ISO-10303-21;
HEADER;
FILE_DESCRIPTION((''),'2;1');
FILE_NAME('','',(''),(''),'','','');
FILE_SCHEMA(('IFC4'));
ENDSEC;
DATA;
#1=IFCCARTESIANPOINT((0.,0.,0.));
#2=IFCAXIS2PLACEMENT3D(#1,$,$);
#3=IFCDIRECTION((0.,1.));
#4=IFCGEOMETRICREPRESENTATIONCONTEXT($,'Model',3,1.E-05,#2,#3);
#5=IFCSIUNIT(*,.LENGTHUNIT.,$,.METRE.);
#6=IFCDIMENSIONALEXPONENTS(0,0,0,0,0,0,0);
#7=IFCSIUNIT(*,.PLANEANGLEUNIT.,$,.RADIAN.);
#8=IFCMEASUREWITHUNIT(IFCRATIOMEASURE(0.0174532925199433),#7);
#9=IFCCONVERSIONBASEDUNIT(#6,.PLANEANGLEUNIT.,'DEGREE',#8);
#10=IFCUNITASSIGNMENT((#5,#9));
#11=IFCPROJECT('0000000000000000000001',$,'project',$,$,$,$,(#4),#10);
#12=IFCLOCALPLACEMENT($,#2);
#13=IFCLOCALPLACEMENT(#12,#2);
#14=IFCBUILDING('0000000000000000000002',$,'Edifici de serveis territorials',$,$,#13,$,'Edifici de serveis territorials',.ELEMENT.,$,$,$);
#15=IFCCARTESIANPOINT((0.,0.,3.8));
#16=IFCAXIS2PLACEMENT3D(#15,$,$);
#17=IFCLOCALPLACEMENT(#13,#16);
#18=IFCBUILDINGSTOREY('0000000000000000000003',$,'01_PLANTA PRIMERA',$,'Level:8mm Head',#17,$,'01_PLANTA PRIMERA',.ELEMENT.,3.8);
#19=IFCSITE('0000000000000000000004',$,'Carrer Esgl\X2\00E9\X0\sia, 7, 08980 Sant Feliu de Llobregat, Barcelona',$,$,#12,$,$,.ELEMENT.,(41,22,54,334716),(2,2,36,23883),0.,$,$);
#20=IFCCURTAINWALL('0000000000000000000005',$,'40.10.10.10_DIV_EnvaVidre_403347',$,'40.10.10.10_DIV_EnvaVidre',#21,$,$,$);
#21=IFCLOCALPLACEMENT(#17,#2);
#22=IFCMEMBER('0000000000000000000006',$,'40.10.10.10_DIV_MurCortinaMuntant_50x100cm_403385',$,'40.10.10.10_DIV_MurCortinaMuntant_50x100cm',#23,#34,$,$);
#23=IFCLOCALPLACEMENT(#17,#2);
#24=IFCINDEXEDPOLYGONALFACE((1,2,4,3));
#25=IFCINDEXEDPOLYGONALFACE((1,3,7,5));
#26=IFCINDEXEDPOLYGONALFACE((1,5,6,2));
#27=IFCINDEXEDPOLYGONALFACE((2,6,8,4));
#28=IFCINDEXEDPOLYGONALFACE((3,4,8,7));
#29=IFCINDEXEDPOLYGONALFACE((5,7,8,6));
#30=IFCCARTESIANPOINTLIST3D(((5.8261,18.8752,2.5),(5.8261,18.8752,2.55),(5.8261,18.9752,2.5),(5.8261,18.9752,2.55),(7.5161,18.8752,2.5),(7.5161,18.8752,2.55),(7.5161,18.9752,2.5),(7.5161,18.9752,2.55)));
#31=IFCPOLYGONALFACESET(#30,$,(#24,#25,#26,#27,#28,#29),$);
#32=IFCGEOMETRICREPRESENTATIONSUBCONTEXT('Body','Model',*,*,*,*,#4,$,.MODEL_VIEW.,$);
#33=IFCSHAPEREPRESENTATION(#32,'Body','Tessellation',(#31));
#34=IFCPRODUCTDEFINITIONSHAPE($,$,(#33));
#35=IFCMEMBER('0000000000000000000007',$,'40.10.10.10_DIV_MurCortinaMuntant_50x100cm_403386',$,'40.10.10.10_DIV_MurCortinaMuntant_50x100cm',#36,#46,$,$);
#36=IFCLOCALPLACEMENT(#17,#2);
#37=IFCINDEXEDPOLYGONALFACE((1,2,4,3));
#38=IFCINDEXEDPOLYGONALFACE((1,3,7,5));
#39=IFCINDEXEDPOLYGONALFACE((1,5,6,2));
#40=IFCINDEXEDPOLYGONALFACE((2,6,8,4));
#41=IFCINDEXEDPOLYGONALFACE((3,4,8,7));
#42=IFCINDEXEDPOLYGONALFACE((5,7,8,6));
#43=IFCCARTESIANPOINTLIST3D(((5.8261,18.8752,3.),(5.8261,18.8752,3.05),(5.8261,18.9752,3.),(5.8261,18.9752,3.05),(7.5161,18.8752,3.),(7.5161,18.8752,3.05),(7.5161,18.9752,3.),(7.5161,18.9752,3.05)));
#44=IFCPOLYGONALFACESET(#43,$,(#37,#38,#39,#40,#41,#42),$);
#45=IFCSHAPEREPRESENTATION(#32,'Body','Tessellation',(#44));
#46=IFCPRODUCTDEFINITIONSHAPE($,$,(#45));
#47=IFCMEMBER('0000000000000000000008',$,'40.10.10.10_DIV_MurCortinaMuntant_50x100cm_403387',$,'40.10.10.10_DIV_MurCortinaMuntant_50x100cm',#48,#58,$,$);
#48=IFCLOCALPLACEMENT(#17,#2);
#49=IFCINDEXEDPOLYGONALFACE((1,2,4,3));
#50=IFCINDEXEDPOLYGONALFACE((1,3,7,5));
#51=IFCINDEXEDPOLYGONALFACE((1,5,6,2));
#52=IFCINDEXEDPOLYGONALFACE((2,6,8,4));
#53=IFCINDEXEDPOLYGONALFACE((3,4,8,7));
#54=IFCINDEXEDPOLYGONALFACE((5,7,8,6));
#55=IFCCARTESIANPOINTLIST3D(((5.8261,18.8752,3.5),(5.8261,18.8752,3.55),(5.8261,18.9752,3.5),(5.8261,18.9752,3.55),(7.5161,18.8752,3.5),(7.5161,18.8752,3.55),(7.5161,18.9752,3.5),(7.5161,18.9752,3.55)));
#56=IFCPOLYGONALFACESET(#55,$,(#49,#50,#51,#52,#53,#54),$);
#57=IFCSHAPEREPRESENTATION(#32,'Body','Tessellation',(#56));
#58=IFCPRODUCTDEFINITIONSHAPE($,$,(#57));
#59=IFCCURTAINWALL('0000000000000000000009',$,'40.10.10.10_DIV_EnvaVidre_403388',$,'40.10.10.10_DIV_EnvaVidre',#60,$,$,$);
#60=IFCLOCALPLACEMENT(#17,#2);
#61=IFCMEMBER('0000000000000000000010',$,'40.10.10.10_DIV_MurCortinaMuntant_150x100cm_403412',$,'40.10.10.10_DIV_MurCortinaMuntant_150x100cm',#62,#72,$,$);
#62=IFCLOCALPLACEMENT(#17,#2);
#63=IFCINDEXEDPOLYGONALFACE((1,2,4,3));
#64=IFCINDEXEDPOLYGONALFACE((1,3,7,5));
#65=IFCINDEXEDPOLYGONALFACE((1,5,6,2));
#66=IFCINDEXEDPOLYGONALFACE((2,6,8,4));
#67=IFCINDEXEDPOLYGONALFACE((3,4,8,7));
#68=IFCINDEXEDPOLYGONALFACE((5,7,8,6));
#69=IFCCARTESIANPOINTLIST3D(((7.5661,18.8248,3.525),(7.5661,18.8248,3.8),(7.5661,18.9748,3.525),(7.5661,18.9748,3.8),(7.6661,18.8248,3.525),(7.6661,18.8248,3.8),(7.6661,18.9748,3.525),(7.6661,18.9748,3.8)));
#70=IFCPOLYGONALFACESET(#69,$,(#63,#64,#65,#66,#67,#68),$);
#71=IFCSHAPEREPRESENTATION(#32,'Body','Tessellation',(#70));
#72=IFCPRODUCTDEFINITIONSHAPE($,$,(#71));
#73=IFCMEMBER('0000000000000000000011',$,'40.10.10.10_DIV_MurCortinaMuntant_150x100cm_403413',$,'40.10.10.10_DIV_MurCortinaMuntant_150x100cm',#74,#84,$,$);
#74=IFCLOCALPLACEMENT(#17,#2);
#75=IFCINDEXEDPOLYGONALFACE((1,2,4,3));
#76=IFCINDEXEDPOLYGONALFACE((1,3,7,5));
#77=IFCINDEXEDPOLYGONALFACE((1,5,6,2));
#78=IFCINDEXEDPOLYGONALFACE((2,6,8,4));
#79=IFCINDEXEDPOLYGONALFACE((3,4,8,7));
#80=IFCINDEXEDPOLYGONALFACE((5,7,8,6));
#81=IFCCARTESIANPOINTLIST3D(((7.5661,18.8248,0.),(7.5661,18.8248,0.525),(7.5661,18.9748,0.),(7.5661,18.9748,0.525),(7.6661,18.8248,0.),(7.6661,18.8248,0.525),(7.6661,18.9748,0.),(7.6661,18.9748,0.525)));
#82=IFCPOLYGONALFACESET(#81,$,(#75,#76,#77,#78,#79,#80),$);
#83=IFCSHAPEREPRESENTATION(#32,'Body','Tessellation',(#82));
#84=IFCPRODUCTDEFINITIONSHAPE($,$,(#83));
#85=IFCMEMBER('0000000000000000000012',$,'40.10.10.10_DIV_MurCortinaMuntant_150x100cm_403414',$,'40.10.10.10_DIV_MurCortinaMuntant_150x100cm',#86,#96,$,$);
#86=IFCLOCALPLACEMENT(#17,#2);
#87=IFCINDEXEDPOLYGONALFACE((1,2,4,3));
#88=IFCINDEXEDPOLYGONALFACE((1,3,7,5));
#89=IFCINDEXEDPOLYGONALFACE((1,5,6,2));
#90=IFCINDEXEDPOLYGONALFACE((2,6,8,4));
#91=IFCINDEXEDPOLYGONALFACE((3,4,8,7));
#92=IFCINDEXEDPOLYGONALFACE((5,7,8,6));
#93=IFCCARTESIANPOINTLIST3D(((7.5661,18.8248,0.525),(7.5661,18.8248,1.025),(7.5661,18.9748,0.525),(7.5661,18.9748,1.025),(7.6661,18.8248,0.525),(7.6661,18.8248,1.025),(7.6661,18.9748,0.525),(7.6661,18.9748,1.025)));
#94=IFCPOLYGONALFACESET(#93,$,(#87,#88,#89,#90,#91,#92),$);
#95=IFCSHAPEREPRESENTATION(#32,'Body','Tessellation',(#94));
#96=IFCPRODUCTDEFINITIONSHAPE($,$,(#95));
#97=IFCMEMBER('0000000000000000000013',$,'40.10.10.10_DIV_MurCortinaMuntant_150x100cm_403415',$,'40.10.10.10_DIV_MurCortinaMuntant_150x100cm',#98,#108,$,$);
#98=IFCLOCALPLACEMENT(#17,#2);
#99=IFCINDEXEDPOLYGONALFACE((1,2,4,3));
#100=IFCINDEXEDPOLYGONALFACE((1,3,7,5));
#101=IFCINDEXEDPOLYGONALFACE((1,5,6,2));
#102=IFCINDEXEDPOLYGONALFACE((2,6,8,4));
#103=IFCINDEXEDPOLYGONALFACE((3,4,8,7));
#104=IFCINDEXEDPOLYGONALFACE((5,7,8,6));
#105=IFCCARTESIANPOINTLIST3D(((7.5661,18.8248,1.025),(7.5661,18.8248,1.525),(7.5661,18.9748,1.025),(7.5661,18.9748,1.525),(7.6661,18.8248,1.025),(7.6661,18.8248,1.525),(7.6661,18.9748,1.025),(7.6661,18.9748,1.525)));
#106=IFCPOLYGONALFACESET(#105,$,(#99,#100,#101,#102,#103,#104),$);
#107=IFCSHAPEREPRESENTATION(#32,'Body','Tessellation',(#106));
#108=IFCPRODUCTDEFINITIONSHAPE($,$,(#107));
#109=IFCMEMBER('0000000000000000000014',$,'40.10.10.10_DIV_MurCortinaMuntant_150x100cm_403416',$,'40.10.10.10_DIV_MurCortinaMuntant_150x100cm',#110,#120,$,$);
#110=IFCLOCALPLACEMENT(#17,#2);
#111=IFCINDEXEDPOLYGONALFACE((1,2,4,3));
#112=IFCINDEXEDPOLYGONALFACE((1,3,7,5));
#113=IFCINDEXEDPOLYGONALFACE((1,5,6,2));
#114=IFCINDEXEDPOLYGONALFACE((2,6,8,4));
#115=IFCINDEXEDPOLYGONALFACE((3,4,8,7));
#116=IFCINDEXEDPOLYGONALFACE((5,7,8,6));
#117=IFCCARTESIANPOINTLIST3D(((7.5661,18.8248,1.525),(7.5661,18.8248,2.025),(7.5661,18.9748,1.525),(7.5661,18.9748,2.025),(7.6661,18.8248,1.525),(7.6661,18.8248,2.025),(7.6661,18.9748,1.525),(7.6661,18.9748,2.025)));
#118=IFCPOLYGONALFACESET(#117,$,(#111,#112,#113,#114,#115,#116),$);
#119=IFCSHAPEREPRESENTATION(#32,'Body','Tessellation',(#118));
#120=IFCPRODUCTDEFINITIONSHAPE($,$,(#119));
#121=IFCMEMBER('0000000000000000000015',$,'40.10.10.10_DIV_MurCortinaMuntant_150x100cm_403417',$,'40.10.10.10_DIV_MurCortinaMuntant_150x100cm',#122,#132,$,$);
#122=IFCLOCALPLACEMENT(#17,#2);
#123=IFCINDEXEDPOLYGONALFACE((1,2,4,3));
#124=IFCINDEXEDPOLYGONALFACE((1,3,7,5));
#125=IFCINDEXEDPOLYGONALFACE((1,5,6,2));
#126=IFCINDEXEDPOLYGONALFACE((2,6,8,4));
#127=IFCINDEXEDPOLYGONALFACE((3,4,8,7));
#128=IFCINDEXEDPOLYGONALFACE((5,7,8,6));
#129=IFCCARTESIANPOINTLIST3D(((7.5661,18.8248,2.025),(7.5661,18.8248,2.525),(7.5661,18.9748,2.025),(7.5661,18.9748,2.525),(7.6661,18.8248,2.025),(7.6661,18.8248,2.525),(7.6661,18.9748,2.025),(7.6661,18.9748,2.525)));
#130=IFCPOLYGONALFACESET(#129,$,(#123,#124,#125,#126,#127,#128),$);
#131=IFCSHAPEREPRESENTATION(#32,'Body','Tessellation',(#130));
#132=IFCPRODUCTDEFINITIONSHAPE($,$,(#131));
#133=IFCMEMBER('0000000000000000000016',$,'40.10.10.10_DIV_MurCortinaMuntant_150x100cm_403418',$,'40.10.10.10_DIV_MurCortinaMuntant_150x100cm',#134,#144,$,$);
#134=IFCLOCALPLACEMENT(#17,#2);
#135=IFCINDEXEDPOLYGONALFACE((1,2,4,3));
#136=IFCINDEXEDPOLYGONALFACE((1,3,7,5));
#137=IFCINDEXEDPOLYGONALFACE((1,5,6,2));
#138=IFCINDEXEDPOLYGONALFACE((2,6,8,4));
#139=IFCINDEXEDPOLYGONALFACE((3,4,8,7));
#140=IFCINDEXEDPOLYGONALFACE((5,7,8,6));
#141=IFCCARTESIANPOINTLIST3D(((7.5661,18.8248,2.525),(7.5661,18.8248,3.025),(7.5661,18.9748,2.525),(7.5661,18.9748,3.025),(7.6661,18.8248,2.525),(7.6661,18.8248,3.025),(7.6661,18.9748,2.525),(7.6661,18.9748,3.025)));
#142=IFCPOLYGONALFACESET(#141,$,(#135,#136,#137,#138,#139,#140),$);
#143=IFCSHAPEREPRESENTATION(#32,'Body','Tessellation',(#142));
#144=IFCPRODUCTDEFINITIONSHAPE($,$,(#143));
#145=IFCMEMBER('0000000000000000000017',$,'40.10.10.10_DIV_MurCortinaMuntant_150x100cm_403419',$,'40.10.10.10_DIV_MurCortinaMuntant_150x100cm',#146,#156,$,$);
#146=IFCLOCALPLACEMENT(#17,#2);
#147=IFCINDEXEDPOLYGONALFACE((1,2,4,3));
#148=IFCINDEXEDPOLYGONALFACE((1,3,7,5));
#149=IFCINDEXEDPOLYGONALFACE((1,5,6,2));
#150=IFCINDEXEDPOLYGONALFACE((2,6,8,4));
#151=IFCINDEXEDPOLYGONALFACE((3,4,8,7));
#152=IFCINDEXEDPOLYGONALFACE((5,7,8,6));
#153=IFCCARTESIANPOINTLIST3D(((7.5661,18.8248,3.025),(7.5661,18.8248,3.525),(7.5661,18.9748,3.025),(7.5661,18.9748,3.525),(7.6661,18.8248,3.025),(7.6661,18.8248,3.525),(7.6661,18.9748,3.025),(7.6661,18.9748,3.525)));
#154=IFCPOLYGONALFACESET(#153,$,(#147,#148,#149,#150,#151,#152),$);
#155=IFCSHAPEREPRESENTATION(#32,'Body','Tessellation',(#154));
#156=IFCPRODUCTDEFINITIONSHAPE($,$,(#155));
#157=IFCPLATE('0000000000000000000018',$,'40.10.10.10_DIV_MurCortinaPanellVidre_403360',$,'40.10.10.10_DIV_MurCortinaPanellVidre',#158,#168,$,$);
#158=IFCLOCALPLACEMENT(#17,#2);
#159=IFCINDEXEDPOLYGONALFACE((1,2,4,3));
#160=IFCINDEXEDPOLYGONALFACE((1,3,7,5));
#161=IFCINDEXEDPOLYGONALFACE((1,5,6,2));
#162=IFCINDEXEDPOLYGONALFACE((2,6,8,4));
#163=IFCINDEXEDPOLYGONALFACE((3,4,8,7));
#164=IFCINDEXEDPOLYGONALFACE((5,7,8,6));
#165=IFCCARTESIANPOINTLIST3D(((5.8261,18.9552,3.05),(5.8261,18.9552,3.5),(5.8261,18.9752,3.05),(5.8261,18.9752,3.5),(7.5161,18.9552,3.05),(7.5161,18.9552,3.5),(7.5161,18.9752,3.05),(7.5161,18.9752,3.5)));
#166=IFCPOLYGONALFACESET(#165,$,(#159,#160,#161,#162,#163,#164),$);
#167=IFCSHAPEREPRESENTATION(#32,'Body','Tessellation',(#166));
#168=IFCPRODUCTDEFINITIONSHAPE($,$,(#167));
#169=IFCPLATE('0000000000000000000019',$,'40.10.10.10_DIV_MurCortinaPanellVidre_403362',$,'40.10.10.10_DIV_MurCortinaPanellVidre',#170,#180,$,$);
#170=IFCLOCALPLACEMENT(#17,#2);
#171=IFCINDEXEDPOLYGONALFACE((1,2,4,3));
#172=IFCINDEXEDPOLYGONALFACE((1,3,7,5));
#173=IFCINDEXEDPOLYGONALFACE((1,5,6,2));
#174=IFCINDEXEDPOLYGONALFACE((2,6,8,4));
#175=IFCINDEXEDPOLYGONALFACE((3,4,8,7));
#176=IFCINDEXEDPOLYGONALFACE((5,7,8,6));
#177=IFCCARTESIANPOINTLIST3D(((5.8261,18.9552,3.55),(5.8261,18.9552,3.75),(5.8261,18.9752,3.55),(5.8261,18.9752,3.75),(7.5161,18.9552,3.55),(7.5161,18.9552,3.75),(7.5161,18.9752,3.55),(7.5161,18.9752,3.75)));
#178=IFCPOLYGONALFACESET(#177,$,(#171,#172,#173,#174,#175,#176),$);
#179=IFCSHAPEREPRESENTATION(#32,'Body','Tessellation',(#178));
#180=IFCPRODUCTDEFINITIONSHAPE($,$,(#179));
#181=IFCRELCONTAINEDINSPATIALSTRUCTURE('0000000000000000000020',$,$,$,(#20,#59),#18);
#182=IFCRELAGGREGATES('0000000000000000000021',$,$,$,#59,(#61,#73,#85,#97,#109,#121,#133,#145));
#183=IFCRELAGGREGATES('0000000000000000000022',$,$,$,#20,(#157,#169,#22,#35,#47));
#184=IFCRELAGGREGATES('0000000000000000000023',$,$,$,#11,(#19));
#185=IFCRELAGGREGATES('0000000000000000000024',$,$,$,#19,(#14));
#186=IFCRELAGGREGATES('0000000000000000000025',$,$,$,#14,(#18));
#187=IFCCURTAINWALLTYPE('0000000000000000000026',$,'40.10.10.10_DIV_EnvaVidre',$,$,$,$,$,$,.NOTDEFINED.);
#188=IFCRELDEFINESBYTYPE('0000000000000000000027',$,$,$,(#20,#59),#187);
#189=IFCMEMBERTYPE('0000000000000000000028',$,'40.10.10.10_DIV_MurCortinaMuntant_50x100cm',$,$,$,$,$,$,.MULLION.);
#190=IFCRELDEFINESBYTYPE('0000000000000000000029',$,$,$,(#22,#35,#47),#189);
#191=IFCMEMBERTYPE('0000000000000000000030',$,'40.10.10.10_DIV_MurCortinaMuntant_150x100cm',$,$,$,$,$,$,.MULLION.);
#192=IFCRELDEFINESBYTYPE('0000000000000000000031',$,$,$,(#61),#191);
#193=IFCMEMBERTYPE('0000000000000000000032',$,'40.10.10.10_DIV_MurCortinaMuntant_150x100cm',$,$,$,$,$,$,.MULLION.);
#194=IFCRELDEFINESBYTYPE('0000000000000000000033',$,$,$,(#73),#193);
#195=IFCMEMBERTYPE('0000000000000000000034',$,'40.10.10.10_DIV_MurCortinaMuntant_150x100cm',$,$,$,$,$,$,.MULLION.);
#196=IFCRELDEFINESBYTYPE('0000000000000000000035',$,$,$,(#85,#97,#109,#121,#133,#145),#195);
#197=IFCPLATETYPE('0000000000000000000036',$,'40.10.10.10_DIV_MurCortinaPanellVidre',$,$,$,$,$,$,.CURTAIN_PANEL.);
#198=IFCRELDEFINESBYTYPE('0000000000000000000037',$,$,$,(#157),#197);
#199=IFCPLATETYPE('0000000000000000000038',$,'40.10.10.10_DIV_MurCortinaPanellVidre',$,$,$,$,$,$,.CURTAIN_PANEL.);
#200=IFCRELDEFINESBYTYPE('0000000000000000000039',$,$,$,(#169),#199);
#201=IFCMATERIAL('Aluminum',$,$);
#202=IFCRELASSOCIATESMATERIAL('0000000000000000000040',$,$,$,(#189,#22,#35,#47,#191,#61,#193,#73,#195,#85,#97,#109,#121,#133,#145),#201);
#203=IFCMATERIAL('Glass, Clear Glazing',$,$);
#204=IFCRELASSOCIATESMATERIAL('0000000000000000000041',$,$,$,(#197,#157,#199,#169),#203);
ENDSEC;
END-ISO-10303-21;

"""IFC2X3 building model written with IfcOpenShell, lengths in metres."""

from ifc_helpers import new_model, entity, si_unit, converted_unit, direction, frame, frame_2d, origin, origin_2d_with_axis, place, context, subcontext, project, spatial, rectangle, extrude, source, transform, mapped, material, type_object, type_shapes, element, aggregate, save


model = new_model("IFC2X3")

# Units and contexts
model_context = context("Model", 3, precision=1e-05, world=origin(), true_north=direction((0.0, 1.0)))
body_context = subcontext(model_context, "Body", "Model", "MODEL_VIEW")
ifc_project = project(units=[si_unit("LENGTHUNIT", "METRE"), converted_unit("PLANEANGLEUNIT", "DEGREE", entity("IfcRatioMeasure", 0.0174532925199433), si_unit("PLANEANGLEUNIT", "RADIAN"), dimensions=[0, 0, 0, 0, 0, 0, 0])], contexts=[model_context])

# Site, building, storey
site_placement = place(None, origin())
site = spatial("IfcSite", under=ifc_project, at=site_placement, Name="Carrer Església, 7, 08980 Sant Feliu de Llobregat, Barcelona", CompositionType="ELEMENT", RefLatitude=(41, 22, 54, 334716), RefLongitude=(2, 2, 36, 23883), RefElevation=0.0)
building_placement = place(site_placement, origin())
building = spatial("IfcBuilding", under=site, at=building_placement, Name="Edifici de serveis territorials", LongName="Edifici de serveis territorials", CompositionType="ELEMENT")
storey_placement = place(building_placement, frame((0.0, 0.0, 3.8)))
storey = spatial("IfcBuildingStorey", under=building, at=storey_placement, Name="01_PLANTA PRIMERA", ObjectType="Level:8mm Head", LongName="01_PLANTA PRIMERA", CompositionType="ELEMENT", Elevation=3.8)

# Curtain walls, members
curtain_wall_type = type_object("IfcCurtainWallType", Name="40.10.10.10_DIV_EnvaVidre", PredefinedType="NOTDEFINED")
curtain_wall_1_placement = place(storey_placement, frame((0.0, 0.0, -3.8)))
curtain_wall_1 = element("IfcCurtainWall", 1, at=curtain_wall_1_placement, inside=storey, type_object=curtain_wall_type, Name="40.10.10.10_DIV_EnvaVidre_403347", ObjectType="40.10.10.10_DIV_EnvaVidre")
ifc_material_1 = material(Name="Aluminum")
member_type_1 = type_object("IfcMemberType", Name="40.10.10.10_DIV_MurCortinaMuntant_50x100cm", PredefinedType="MULLION", material=ifc_material_1)
shared_shape_1 = source(origin(), body_context, "Body", "SweptSolid", [
    extrude(rectangle(XDim=0.1, YDim=0.05, at=origin_2d_with_axis()), frame((0.0, 0.0, -1.69), z_axis=(0.0, 0.0, 1.0), x_axis=(0.0, -1.0, 0.0)), (0.0, 0.0, 1.0), 1.69),
])
type_shapes(member_type_1, [shared_shape_1])
member_1_placement = place(storey_placement, frame((7.5161, 18.9252, 2.525), z_axis=(1.0, 0.0, 0.0), x_axis=(0.0, 0.0, 1.0)))
member_1 = element("IfcMember", 2, at=member_1_placement, type_object=member_type_1, material=ifc_material_1, Name="40.10.10.10_DIV_MurCortinaMuntant_50x100cm_403385", ObjectType="40.10.10.10_DIV_MurCortinaMuntant_50x100cm", context=body_context, shape_type="MappedRepresentation", body=[
    mapped(shared_shape_1, transform((0.0, 0.0, 0.0), scale=1.0)),
])
member_2_placement = place(storey_placement, frame((7.5161, 18.9252, 3.025), z_axis=(1.0, 0.0, 0.0), x_axis=(0.0, 0.0, 1.0)))
member_2 = element("IfcMember", 3, at=member_2_placement, type_object=member_type_1, material=ifc_material_1, Name="40.10.10.10_DIV_MurCortinaMuntant_50x100cm_403386", ObjectType="40.10.10.10_DIV_MurCortinaMuntant_50x100cm", context=body_context, shape_type="MappedRepresentation", body=[
    mapped(shared_shape_1, transform((0.0, 0.0, 0.0), scale=1.0)),
])
member_3_placement = place(storey_placement, frame((7.5161, 18.9252, 3.525), z_axis=(1.0, 0.0, 0.0), x_axis=(0.0, 0.0, 1.0)))
member_3 = element("IfcMember", 4, at=member_3_placement, type_object=member_type_1, material=ifc_material_1, Name="40.10.10.10_DIV_MurCortinaMuntant_50x100cm_403387", ObjectType="40.10.10.10_DIV_MurCortinaMuntant_50x100cm", context=body_context, shape_type="MappedRepresentation", body=[
    mapped(shared_shape_1, transform((0.0, 0.0, 0.0), scale=1.0)),
])
curtain_wall_2_placement = place(storey_placement, frame((0.0, 0.0, -3.8)))
curtain_wall_2 = element("IfcCurtainWall", 5, at=curtain_wall_2_placement, inside=storey, type_object=curtain_wall_type, Name="40.10.10.10_DIV_EnvaVidre_403388", ObjectType="40.10.10.10_DIV_EnvaVidre")
member_type_2 = type_object("IfcMemberType", Name="40.10.10.10_DIV_MurCortinaMuntant_150x100cm", PredefinedType="MULLION", material=ifc_material_1)
shared_shape_2 = source(origin(), body_context, "Body", "SweptSolid", [
    extrude(rectangle(XDim=0.1, YDim=0.15, at=origin_2d_with_axis()), frame((-0.075, 0.0, -0.275), z_axis=(0.0, 0.0, 1.0), x_axis=(0.0, -1.0, 0.0)), (0.0, 0.0, 1.0), 0.275),
])
type_shapes(member_type_2, [shared_shape_2])
member_4_placement = place(storey_placement, frame((7.6161, 18.9748, 3.8), z_axis=(0.0, 0.0, 1.0), x_axis=(0.0, 1.0, 0.0)))
member_4 = element("IfcMember", 6, at=member_4_placement, type_object=member_type_2, material=ifc_material_1, Name="40.10.10.10_DIV_MurCortinaMuntant_150x100cm_403412", ObjectType="40.10.10.10_DIV_MurCortinaMuntant_150x100cm", context=body_context, shape_type="MappedRepresentation", body=[
    mapped(shared_shape_2, transform((0.0, 0.0, 0.0), scale=1.0)),
])
member_type_3 = type_object("IfcMemberType", Name="40.10.10.10_DIV_MurCortinaMuntant_150x100cm", PredefinedType="MULLION", material=ifc_material_1)
shared_shape_3 = source(origin(), body_context, "Body", "SweptSolid", [
    extrude(rectangle(XDim=0.1, YDim=0.15, at=origin_2d_with_axis()), frame((-0.075, 0.0, -0.525), z_axis=(0.0, 0.0, 1.0), x_axis=(0.0, -1.0, 0.0)), (0.0, 0.0, 1.0), 0.525),
])
type_shapes(member_type_3, [shared_shape_3])
member_5_placement = place(storey_placement, frame((7.6161, 18.9748, 0.525), z_axis=(0.0, 0.0, 1.0), x_axis=(0.0, 1.0, 0.0)))
member_5 = element("IfcMember", 7, at=member_5_placement, type_object=member_type_3, material=ifc_material_1, Name="40.10.10.10_DIV_MurCortinaMuntant_150x100cm_403413", ObjectType="40.10.10.10_DIV_MurCortinaMuntant_150x100cm", context=body_context, shape_type="MappedRepresentation", body=[
    mapped(shared_shape_3, transform((0.0, 0.0, 0.0), scale=1.0)),
])
member_type_4 = type_object("IfcMemberType", Name="40.10.10.10_DIV_MurCortinaMuntant_150x100cm", PredefinedType="MULLION", material=ifc_material_1)
shared_shape_4 = source(origin(), body_context, "Body", "SweptSolid", [
    extrude(rectangle(XDim=0.1, YDim=0.15, at=origin_2d_with_axis()), frame((-0.075, 0.0, -0.5), z_axis=(0.0, 0.0, 1.0), x_axis=(0.0, -1.0, 0.0)), (0.0, 0.0, 1.0), 0.5),
])
type_shapes(member_type_4, [shared_shape_4])
member_6_placement = place(storey_placement, frame((7.6161, 18.9748, 1.025), z_axis=(0.0, 0.0, 1.0), x_axis=(0.0, 1.0, 0.0)))
member_6 = element("IfcMember", 8, at=member_6_placement, type_object=member_type_4, material=ifc_material_1, Name="40.10.10.10_DIV_MurCortinaMuntant_150x100cm_403414", ObjectType="40.10.10.10_DIV_MurCortinaMuntant_150x100cm", context=body_context, shape_type="MappedRepresentation", body=[
    mapped(shared_shape_4, transform((0.0, 0.0, 0.0), scale=1.0)),
])
member_7_placement = place(storey_placement, frame((7.6161, 18.9748, 1.525), z_axis=(0.0, 0.0, 1.0), x_axis=(0.0, 1.0, 0.0)))
member_7 = element("IfcMember", 9, at=member_7_placement, type_object=member_type_4, material=ifc_material_1, Name="40.10.10.10_DIV_MurCortinaMuntant_150x100cm_403415", ObjectType="40.10.10.10_DIV_MurCortinaMuntant_150x100cm", context=body_context, shape_type="MappedRepresentation", body=[
    mapped(shared_shape_4, transform((0.0, 0.0, 0.0), scale=1.0)),
])
member_8_placement = place(storey_placement, frame((7.6161, 18.9748, 2.025), z_axis=(0.0, 0.0, 1.0), x_axis=(0.0, 1.0, 0.0)))
member_8 = element("IfcMember", 10, at=member_8_placement, type_object=member_type_4, material=ifc_material_1, Name="40.10.10.10_DIV_MurCortinaMuntant_150x100cm_403416", ObjectType="40.10.10.10_DIV_MurCortinaMuntant_150x100cm", context=body_context, shape_type="MappedRepresentation", body=[
    mapped(shared_shape_4, transform((0.0, 0.0, 0.0), scale=1.0)),
])
member_9_placement = place(storey_placement, frame((7.6161, 18.9748, 2.525), z_axis=(0.0, 0.0, 1.0), x_axis=(0.0, 1.0, 0.0)))
member_9 = element("IfcMember", 11, at=member_9_placement, type_object=member_type_4, material=ifc_material_1, Name="40.10.10.10_DIV_MurCortinaMuntant_150x100cm_403417", ObjectType="40.10.10.10_DIV_MurCortinaMuntant_150x100cm", context=body_context, shape_type="MappedRepresentation", body=[
    mapped(shared_shape_4, transform((0.0, 0.0, 0.0), scale=1.0)),
])
member_10_placement = place(storey_placement, frame((7.6161, 18.9748, 3.025), z_axis=(0.0, 0.0, 1.0), x_axis=(0.0, 1.0, 0.0)))
member_10 = element("IfcMember", 12, at=member_10_placement, type_object=member_type_4, material=ifc_material_1, Name="40.10.10.10_DIV_MurCortinaMuntant_150x100cm_403418", ObjectType="40.10.10.10_DIV_MurCortinaMuntant_150x100cm", context=body_context, shape_type="MappedRepresentation", body=[
    mapped(shared_shape_4, transform((0.0, 0.0, 0.0), scale=1.0)),
])
member_11_placement = place(storey_placement, frame((7.6161, 18.9748, 3.525), z_axis=(0.0, 0.0, 1.0), x_axis=(0.0, 1.0, 0.0)))
member_11 = element("IfcMember", 13, at=member_11_placement, type_object=member_type_4, material=ifc_material_1, Name="40.10.10.10_DIV_MurCortinaMuntant_150x100cm_403419", ObjectType="40.10.10.10_DIV_MurCortinaMuntant_150x100cm", context=body_context, shape_type="MappedRepresentation", body=[
    mapped(shared_shape_4, transform((0.0, 0.0, 0.0), scale=1.0)),
])
aggregate(curtain_wall_2, [member_4, member_5, member_6, member_7, member_8, member_9, member_10, member_11])

# Plates
ifc_material_2 = material(Name="Glass, Clear Glazing")
plate_type_1 = type_object("IfcPlateType", Name="40.10.10.10_DIV_MurCortinaPanellVidre", PredefinedType="CURTAIN_PANEL", material=ifc_material_2)
shared_shape_5 = source(origin(), body_context, "Body", "SweptSolid", [
    extrude(rectangle(XDim=0.02, YDim=1.69, at=frame_2d((0.0, 0.0), x_axis=(1.0, 0.0))), frame((0.845, 0.01, 0.0), z_axis=(0.0, 0.0, 1.0), x_axis=(0.0, 1.0, 0.0)), (0.0, 0.0, 1.0), 0.45),
])
type_shapes(plate_type_1, [shared_shape_5])
plate_1_placement = place(curtain_wall_1_placement, frame((5.8261, 18.9552, 6.85)))
plate_1 = element("IfcPlate", 14, at=plate_1_placement, type_object=plate_type_1, material=ifc_material_2, Name="40.10.10.10_DIV_MurCortinaPanellVidre_403360", ObjectType="40.10.10.10_DIV_MurCortinaPanellVidre", context=body_context, shape_type="MappedRepresentation", body=[
    mapped(shared_shape_5, transform((0.0, 0.0, 0.0), scale=1.0)),
])
plate_type_2 = type_object("IfcPlateType", Name="40.10.10.10_DIV_MurCortinaPanellVidre", PredefinedType="CURTAIN_PANEL", material=ifc_material_2)
shared_shape_6 = source(origin(), body_context, "Body", "SweptSolid", [
    extrude(rectangle(XDim=0.02, YDim=1.69, at=frame_2d((0.0, 0.0), x_axis=(1.0, 0.0))), frame((0.845, 0.01, 0.0), z_axis=(0.0, 0.0, 1.0), x_axis=(0.0, 1.0, 0.0)), (0.0, 0.0, 1.0), 0.2),
])
type_shapes(plate_type_2, [shared_shape_6])
plate_2_placement = place(curtain_wall_1_placement, frame((5.8261, 18.9552, 7.35)))
plate_2 = element("IfcPlate", 15, at=plate_2_placement, type_object=plate_type_2, material=ifc_material_2, Name="40.10.10.10_DIV_MurCortinaPanellVidre_403362", ObjectType="40.10.10.10_DIV_MurCortinaPanellVidre", context=body_context, shape_type="MappedRepresentation", body=[
    mapped(shared_shape_6, transform((0.0, 0.0, 0.0), scale=1.0)),
])
aggregate(curtain_wall_1, [plate_1, plate_2, member_1, member_2, member_3])

save(model, "model.ifc")
